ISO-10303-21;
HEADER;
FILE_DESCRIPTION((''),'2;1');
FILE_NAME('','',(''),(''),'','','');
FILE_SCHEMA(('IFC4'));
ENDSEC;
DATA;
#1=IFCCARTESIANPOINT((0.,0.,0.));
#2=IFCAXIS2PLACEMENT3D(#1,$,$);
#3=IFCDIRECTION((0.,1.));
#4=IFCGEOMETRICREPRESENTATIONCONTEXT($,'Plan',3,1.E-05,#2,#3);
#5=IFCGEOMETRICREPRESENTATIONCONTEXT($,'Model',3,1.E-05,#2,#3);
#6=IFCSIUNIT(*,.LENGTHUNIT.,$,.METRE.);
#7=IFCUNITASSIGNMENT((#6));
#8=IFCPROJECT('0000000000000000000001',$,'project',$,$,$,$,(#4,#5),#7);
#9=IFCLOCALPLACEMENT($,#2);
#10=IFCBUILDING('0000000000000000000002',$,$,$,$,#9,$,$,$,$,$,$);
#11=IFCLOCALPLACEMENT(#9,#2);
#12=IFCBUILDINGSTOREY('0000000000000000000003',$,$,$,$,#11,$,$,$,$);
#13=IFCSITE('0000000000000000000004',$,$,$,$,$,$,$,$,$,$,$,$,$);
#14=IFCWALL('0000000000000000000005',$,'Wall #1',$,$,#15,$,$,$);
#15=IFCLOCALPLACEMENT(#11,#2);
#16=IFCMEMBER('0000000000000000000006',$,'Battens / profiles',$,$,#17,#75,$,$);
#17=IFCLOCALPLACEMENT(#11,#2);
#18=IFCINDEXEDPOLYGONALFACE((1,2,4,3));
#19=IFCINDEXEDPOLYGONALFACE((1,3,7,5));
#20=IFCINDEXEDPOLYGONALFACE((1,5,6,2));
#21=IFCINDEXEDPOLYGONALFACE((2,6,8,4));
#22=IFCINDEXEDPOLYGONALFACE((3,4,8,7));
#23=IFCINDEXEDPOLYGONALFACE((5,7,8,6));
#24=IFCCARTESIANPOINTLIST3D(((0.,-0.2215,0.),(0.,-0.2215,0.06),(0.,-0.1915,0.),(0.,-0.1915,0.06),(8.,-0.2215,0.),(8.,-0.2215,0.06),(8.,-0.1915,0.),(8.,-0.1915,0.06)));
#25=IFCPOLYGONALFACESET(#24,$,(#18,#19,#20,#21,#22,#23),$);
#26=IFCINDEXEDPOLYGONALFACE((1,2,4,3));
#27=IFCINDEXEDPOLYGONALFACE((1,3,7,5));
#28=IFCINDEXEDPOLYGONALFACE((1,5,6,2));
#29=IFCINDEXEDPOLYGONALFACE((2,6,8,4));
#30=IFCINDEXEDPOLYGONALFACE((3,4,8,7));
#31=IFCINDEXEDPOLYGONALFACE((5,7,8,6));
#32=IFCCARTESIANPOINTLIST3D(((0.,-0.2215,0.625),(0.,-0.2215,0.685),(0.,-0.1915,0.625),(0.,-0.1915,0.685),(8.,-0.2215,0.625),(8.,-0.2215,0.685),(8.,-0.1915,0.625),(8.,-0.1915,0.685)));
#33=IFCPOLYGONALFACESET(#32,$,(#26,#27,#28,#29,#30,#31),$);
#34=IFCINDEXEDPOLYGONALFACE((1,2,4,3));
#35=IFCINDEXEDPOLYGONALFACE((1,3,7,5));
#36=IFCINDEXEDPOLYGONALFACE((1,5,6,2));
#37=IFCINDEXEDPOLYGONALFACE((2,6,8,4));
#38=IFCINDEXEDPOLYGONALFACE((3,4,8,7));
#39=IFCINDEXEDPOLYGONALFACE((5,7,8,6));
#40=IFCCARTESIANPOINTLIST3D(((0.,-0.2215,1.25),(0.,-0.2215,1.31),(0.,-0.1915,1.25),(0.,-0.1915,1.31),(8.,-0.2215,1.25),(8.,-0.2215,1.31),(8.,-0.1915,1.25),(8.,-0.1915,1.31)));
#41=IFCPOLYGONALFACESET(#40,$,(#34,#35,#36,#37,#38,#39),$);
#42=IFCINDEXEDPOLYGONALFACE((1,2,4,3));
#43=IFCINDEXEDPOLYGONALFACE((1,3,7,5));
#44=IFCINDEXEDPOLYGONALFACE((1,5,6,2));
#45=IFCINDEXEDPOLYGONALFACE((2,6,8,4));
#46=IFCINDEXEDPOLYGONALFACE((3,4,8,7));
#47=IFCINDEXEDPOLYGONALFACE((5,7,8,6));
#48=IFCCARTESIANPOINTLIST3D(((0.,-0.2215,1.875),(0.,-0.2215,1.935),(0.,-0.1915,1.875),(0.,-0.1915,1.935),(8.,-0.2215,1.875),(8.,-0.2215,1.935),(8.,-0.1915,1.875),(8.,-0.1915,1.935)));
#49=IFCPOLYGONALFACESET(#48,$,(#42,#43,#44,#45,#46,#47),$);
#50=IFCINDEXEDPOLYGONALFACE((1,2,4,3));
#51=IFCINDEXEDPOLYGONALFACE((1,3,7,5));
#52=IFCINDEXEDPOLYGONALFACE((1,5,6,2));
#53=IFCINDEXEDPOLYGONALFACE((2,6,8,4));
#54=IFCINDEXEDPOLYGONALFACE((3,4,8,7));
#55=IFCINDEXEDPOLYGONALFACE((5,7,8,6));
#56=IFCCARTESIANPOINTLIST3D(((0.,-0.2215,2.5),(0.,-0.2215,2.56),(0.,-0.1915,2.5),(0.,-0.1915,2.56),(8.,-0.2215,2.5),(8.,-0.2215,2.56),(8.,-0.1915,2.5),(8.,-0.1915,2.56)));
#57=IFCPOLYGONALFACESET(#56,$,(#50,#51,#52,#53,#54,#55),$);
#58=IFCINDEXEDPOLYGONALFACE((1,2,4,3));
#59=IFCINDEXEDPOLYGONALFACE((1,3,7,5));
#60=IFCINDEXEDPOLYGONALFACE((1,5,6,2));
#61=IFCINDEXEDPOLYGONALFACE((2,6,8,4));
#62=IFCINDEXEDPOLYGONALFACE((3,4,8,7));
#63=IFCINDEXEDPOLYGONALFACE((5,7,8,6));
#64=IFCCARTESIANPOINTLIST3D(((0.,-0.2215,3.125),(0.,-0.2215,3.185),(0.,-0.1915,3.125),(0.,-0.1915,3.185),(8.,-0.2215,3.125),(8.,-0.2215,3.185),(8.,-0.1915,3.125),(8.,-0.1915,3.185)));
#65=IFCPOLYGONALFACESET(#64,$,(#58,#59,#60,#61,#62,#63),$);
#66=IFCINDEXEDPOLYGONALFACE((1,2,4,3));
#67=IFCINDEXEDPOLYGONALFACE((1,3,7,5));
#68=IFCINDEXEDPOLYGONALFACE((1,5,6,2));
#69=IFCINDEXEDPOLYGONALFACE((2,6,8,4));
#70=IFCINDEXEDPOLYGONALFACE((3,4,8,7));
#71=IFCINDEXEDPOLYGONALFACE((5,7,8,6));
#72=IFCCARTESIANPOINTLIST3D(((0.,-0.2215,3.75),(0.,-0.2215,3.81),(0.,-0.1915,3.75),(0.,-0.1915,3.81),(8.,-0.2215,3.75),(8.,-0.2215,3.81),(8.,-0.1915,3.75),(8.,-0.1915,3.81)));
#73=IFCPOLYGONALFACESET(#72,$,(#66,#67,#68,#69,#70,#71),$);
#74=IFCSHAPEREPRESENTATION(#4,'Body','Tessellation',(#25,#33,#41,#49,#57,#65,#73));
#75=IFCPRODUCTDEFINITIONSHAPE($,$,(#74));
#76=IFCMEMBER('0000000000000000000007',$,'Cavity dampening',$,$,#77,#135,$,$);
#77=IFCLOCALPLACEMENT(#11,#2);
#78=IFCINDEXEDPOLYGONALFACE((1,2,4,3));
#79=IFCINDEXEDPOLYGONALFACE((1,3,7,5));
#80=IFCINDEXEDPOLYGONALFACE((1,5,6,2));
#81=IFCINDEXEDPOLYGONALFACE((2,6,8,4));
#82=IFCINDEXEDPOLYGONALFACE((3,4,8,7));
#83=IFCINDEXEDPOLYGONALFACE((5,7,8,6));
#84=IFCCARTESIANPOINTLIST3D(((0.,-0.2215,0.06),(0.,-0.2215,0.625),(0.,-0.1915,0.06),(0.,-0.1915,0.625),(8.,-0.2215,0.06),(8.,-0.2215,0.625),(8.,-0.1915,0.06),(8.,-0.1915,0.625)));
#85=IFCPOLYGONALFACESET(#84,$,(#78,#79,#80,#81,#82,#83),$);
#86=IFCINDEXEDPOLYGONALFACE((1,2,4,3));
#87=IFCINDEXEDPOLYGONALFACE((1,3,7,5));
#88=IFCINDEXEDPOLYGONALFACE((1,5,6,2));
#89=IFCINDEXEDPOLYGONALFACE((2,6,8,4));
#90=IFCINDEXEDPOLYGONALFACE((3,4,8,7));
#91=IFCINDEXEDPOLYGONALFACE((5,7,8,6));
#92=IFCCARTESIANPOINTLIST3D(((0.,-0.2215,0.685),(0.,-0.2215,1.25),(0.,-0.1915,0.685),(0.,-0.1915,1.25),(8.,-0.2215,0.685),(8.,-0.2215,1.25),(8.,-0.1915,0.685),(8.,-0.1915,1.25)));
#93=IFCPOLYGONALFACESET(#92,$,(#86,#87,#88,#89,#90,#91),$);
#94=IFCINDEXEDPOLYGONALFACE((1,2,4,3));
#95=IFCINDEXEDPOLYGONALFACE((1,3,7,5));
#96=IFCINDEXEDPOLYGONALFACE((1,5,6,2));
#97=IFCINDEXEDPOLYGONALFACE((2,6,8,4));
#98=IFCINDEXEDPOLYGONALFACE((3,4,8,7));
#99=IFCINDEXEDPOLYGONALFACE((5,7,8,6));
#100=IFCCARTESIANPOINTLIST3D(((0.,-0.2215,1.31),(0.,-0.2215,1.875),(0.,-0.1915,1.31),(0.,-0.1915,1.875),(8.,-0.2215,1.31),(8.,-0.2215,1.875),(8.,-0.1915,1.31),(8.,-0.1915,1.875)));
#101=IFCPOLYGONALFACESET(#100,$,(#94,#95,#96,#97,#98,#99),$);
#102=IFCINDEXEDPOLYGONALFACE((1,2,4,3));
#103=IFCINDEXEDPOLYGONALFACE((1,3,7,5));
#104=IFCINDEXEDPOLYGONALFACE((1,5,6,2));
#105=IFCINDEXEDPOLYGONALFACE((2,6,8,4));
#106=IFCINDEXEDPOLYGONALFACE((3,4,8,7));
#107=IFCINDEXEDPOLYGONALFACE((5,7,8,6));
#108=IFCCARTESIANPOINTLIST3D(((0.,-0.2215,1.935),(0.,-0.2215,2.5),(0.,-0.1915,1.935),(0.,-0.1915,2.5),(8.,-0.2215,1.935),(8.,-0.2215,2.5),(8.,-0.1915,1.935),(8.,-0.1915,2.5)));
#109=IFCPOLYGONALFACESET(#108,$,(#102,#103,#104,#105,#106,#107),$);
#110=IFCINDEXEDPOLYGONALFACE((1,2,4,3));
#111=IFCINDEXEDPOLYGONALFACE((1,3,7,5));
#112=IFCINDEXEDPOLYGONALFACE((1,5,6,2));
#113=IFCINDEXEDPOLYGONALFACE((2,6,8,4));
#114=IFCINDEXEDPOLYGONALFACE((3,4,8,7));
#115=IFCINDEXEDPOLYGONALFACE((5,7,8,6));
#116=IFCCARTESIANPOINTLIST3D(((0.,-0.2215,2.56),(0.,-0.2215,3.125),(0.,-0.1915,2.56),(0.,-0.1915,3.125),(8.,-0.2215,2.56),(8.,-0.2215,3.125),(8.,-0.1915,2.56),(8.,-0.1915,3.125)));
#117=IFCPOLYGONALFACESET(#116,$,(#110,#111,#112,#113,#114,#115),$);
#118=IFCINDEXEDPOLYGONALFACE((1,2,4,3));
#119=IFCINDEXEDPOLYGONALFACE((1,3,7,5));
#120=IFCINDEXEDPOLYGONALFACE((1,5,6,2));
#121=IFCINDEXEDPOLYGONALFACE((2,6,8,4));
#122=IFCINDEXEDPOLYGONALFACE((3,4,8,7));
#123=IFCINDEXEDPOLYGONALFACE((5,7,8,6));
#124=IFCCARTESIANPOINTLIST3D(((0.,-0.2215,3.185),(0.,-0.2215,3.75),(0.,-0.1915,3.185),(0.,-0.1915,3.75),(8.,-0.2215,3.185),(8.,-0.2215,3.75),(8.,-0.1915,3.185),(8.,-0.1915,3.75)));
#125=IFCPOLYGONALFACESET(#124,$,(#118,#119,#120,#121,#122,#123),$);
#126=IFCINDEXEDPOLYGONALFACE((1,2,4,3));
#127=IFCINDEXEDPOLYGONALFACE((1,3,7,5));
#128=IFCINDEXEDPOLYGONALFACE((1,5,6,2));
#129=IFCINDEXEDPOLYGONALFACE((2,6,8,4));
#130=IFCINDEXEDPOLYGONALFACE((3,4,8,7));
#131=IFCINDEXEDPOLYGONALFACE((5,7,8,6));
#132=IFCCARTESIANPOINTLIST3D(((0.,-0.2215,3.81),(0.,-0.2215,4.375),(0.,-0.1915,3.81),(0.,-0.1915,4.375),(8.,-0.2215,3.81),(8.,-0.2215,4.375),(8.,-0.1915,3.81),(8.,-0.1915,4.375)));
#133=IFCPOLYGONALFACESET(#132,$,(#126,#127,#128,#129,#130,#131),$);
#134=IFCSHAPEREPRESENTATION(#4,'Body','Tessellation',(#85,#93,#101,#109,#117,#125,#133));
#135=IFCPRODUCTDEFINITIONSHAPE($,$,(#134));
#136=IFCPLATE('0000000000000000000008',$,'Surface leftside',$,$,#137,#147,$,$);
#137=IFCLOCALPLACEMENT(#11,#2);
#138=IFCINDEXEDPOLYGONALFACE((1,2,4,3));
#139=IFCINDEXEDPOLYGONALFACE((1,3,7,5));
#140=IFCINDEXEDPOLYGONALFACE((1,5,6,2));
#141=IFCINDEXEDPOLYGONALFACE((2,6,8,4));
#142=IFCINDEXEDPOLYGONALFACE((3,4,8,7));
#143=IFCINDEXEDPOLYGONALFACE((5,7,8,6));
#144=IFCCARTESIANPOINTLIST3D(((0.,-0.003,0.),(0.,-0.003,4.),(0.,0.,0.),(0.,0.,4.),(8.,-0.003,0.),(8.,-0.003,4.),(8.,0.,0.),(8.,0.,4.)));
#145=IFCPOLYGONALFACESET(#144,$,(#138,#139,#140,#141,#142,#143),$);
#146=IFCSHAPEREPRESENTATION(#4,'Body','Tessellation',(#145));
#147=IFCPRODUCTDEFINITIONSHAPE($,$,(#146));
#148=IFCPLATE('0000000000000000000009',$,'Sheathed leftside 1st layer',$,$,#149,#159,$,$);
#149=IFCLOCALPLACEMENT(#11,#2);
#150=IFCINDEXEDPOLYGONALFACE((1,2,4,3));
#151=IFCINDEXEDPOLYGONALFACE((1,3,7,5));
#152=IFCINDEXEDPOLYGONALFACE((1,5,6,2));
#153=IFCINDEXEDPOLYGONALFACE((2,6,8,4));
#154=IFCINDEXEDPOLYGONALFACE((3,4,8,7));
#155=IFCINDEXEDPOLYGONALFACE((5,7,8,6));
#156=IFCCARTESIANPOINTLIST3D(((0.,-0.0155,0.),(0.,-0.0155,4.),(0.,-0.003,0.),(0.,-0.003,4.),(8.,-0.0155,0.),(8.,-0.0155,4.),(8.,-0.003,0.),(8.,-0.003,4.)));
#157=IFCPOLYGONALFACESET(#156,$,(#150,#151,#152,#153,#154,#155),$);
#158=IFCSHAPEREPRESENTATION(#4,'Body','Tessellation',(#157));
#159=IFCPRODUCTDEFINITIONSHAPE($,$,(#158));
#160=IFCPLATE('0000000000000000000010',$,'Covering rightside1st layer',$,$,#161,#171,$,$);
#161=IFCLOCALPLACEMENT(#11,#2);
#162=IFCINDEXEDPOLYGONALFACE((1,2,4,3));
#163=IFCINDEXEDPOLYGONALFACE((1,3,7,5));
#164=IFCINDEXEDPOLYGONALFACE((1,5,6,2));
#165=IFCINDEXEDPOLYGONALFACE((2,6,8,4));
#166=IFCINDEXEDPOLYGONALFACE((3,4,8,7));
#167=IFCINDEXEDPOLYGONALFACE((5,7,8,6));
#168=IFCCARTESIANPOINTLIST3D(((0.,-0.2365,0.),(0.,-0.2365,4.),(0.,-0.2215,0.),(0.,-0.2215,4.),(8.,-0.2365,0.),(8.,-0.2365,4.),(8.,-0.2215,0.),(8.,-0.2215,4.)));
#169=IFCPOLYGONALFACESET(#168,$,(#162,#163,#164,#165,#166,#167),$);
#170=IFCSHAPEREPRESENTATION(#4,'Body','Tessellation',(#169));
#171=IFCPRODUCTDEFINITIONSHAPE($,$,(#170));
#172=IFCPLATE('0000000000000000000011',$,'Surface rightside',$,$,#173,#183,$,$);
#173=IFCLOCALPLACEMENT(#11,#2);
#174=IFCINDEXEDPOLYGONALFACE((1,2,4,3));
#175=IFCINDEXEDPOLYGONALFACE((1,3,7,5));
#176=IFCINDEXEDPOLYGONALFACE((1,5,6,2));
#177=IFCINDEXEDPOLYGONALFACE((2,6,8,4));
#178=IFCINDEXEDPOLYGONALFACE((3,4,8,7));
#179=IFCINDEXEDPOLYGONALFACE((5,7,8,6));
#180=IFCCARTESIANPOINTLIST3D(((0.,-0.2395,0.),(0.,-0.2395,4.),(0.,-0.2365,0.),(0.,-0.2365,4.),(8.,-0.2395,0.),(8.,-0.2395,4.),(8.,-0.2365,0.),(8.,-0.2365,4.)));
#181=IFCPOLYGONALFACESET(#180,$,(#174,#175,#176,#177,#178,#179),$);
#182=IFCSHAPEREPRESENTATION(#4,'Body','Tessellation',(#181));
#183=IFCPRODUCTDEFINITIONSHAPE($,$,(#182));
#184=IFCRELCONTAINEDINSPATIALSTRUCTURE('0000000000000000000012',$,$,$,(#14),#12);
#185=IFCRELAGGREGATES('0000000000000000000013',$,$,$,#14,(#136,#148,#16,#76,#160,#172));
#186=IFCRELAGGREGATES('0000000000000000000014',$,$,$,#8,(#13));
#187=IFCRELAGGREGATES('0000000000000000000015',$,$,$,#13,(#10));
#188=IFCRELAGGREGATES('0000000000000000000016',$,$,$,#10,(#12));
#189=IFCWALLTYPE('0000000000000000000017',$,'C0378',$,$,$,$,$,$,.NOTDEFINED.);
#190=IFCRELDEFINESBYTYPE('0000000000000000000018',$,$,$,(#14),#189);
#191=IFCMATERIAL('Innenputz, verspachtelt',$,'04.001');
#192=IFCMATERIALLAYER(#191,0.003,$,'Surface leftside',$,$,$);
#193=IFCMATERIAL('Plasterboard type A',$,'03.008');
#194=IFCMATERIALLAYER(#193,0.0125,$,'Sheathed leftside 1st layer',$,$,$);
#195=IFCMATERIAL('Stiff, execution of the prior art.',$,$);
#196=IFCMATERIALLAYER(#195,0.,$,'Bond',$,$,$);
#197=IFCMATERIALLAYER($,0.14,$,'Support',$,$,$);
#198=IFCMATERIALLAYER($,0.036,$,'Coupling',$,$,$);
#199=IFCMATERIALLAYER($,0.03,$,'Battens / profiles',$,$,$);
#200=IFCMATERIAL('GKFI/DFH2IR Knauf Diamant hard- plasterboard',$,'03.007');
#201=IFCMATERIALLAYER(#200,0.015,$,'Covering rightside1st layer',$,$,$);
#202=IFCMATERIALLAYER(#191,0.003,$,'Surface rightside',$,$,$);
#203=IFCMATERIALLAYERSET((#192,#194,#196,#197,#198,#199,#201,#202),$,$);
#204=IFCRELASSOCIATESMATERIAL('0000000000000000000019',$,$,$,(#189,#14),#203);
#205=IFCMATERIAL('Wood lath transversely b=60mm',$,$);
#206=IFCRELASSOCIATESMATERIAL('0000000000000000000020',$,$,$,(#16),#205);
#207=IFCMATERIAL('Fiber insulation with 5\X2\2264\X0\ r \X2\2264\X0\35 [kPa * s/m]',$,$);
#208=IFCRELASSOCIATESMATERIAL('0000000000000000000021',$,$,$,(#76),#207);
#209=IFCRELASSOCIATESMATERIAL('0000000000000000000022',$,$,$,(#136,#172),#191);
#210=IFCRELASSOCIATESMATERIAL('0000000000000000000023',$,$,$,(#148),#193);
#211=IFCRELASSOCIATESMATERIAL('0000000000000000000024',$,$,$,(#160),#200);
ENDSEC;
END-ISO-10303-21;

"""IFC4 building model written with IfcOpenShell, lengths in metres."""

from ifc_helpers import new_model, si_unit, direction, frame, frame_2d, origin, origin_with_axes, place, context, project, spatial, rectangle, extrude, material, layer, layer_set, type_object, element, aggregate, save


model = new_model("IFC4")

# Units and contexts
plan_context = context("Plan", 3, precision=1e-05, world=origin(), true_north=direction((0.0, 1.0)))
model_context = context("Model", 3, precision=1e-05, world=origin(), true_north=direction((0.0, 1.0)))
ifc_project = project(units=[si_unit("LENGTHUNIT", "METRE")], contexts=[plan_context, model_context])

# Site, building, storey
site = spatial("IfcSite", under=ifc_project)
building_placement = place(None, origin())
building = spatial("IfcBuilding", under=site, at=building_placement)
storey_placement = place(building_placement, origin())
storey = spatial("IfcBuildingStorey", under=building, at=storey_placement)

# Wall, members, plates
ifc_material_1 = material(Name="Innenputz, verspachtelt", Category="04.001")
ifc_layer_1 = layer(ifc_material_1, 0.003, Name="Surface leftside")
ifc_material_2 = material(Name="Plasterboard type A", Category="03.008")
ifc_layer_2 = layer(ifc_material_2, 0.0125, Name="Sheathed leftside 1st layer")
ifc_material_3 = material(Name="Stiff, execution of the prior art.")
ifc_layer_3 = layer(ifc_material_3, 0.0, Name="Bond")
ifc_layer_4 = layer(None, 0.14, Name="Support")
ifc_layer_5 = layer(None, 0.036, Name="Coupling")
ifc_layer_6 = layer(None, 0.03, Name="Battens / profiles")
ifc_material_4 = material(Name="GKFI/DFH2IR Knauf Diamant hard- plasterboard", Category="03.007")
ifc_layer_7 = layer(ifc_material_4, 0.015, Name="Covering rightside1st layer")
ifc_layer_8 = layer(ifc_material_1, 0.003, Name="Surface rightside")
ifc_layer_set = layer_set([ifc_layer_1, ifc_layer_2, ifc_layer_3, ifc_layer_4, ifc_layer_5, ifc_layer_6, ifc_layer_7, ifc_layer_8])
wall_type = type_object("IfcWallType", Name="C0378", PredefinedType="NOTDEFINED", material=ifc_layer_set)
wall_placement = place(None, frame((0.0, 0.0, 0.0), z_axis=(0.0, -1.0, 0.0), x_axis=(1.0, 0.0, 0.0)))
wall = element("IfcWall", 1, at=wall_placement, inside=storey, type_object=wall_type, material=ifc_layer_set, Name="Wall #1")
ifc_material_5 = material(Name="Wood lath transversely b=60mm")
member_1_placement = place(wall_placement, origin())
member_1 = element("IfcMember", 2, at=member_1_placement, material=ifc_material_5, Name="Battens / profiles", context=plan_context, shape_type="SweptSolid", body=[
    extrude(rectangle(XDim=0.06, YDim=0.03, at=frame_2d((0.03, 0.015), x_axis=(1.0, 0.0))), frame((0.0, 0.0, 0.1915), z_axis=(1.0, 0.0, 0.0), x_axis=(0.0, 1.0, 0.0)), (0.0, 0.0, 1.0), 8.0),
    extrude(rectangle(XDim=0.06, YDim=0.03, at=frame_2d((0.03, 0.015), x_axis=(1.0, 0.0))), frame((0.0, 0.625, 0.1915), z_axis=(1.0, 0.0, 0.0), x_axis=(0.0, 1.0, 0.0)), (0.0, 0.0, 1.0), 8.0),
    extrude(rectangle(XDim=0.06, YDim=0.03, at=frame_2d((0.03, 0.015), x_axis=(1.0, 0.0))), frame((0.0, 1.25, 0.1915), z_axis=(1.0, 0.0, 0.0), x_axis=(0.0, 1.0, 0.0)), (0.0, 0.0, 1.0), 8.0),
    extrude(rectangle(XDim=0.06, YDim=0.03, at=frame_2d((0.03, 0.015), x_axis=(1.0, 0.0))), frame((0.0, 1.875, 0.1915), z_axis=(1.0, 0.0, 0.0), x_axis=(0.0, 1.0, 0.0)), (0.0, 0.0, 1.0), 8.0),
    extrude(rectangle(XDim=0.06, YDim=0.03, at=frame_2d((0.03, 0.015), x_axis=(1.0, 0.0))), frame((0.0, 2.5, 0.1915), z_axis=(1.0, 0.0, 0.0), x_axis=(0.0, 1.0, 0.0)), (0.0, 0.0, 1.0), 8.0),
    extrude(rectangle(XDim=0.06, YDim=0.03, at=frame_2d((0.03, 0.015), x_axis=(1.0, 0.0))), frame((0.0, 3.125, 0.1915), z_axis=(1.0, 0.0, 0.0), x_axis=(0.0, 1.0, 0.0)), (0.0, 0.0, 1.0), 8.0),
    extrude(rectangle(XDim=0.06, YDim=0.03, at=frame_2d((0.03, 0.015), x_axis=(1.0, 0.0))), frame((0.0, 3.75, 0.1915), z_axis=(1.0, 0.0, 0.0), x_axis=(0.0, 1.0, 0.0)), (0.0, 0.0, 1.0), 8.0),
])
ifc_material_6 = material(Name="Fiber insulation with 5≤ r ≤35 [kPa * s/m]")
member_2_placement = place(wall_placement, origin())
member_2 = element("IfcMember", 3, at=member_2_placement, material=ifc_material_6, Name="Cavity dampening", context=plan_context, shape_type="SweptSolid", body=[
    extrude(rectangle(XDim=0.565, YDim=0.03, at=frame_2d((0.2825, 0.015), x_axis=(1.0, 0.0))), frame((0.0, 0.06, 0.1915), z_axis=(1.0, 0.0, 0.0), x_axis=(0.0, 1.0, 0.0)), (0.0, 0.0, 1.0), 8.0),
    extrude(rectangle(XDim=0.565, YDim=0.03, at=frame_2d((0.2825, 0.015), x_axis=(1.0, 0.0))), frame((0.0, 0.685, 0.1915), z_axis=(1.0, 0.0, 0.0), x_axis=(0.0, 1.0, 0.0)), (0.0, 0.0, 1.0), 8.0),
    extrude(rectangle(XDim=0.565, YDim=0.03, at=frame_2d((0.2825, 0.015), x_axis=(1.0, 0.0))), frame((0.0, 1.31, 0.1915), z_axis=(1.0, 0.0, 0.0), x_axis=(0.0, 1.0, 0.0)), (0.0, 0.0, 1.0), 8.0),
    extrude(rectangle(XDim=0.565, YDim=0.03, at=frame_2d((0.2825, 0.015), x_axis=(1.0, 0.0))), frame((0.0, 1.935, 0.1915), z_axis=(1.0, 0.0, 0.0), x_axis=(0.0, 1.0, 0.0)), (0.0, 0.0, 1.0), 8.0),
    extrude(rectangle(XDim=0.565, YDim=0.03, at=frame_2d((0.2825, 0.015), x_axis=(1.0, 0.0))), frame((0.0, 2.56, 0.1915), z_axis=(1.0, 0.0, 0.0), x_axis=(0.0, 1.0, 0.0)), (0.0, 0.0, 1.0), 8.0),
    extrude(rectangle(XDim=0.565, YDim=0.03, at=frame_2d((0.2825, 0.015), x_axis=(1.0, 0.0))), frame((0.0, 3.185, 0.1915), z_axis=(1.0, 0.0, 0.0), x_axis=(0.0, 1.0, 0.0)), (0.0, 0.0, 1.0), 8.0),
    extrude(rectangle(XDim=0.565, YDim=0.03, at=frame_2d((0.2825, 0.015), x_axis=(1.0, 0.0))), frame((0.0, 3.81, 0.1915), z_axis=(1.0, 0.0, 0.0), x_axis=(0.0, 1.0, 0.0)), (0.0, 0.0, 1.0), 8.0),
])
plate_1_placement = place(wall_placement, origin())
plate_1 = element("IfcPlate", 4, at=plate_1_placement, material=ifc_material_1, Name="Surface leftside", context=plan_context, shape_type="SweptSolid", body=[
    extrude(rectangle(XDim=8.0, YDim=4.0, at=frame_2d((4.0, 2.0), x_axis=(1.0, 0.0))), origin_with_axes(), (0.0, 0.0, 1.0), 0.003),
])
plate_2_placement = place(wall_placement, origin())
plate_2 = element("IfcPlate", 5, at=plate_2_placement, material=ifc_material_2, Name="Sheathed leftside 1st layer", context=plan_context, shape_type="SweptSolid", body=[
    extrude(rectangle(XDim=8.0, YDim=4.0, at=frame_2d((4.0, 2.0), x_axis=(1.0, 0.0))), frame((0.0, 0.0, 0.003), z_axis=(0.0, 0.0, 1.0), x_axis=(1.0, 0.0, 0.0)), (0.0, 0.0, 1.0), 0.0125),
])
plate_3_placement = place(wall_placement, origin())
plate_3 = element("IfcPlate", 6, at=plate_3_placement, material=ifc_material_4, Name="Covering rightside1st layer", context=plan_context, shape_type="SweptSolid", body=[
    extrude(rectangle(XDim=8.0, YDim=4.0, at=frame_2d((4.0, 2.0), x_axis=(1.0, 0.0))), frame((0.0, 0.0, 0.2215), z_axis=(0.0, 0.0, 1.0), x_axis=(1.0, 0.0, 0.0)), (0.0, 0.0, 1.0), 0.015),
])
plate_4_placement = place(wall_placement, origin())
plate_4 = element("IfcPlate", 7, at=plate_4_placement, material=ifc_material_1, Name="Surface rightside", context=plan_context, shape_type="SweptSolid", body=[
    extrude(rectangle(XDim=8.0, YDim=4.0, at=frame_2d((4.0, 2.0), x_axis=(1.0, 0.0))), frame((0.0, 0.0, 0.2365), z_axis=(0.0, 0.0, 1.0), x_axis=(1.0, 0.0, 0.0)), (0.0, 0.0, 1.0), 0.003),
])
aggregate(wall, [plate_1, plate_2, member_1, member_2, plate_3, plate_4])

save(model, "model.ifc")
